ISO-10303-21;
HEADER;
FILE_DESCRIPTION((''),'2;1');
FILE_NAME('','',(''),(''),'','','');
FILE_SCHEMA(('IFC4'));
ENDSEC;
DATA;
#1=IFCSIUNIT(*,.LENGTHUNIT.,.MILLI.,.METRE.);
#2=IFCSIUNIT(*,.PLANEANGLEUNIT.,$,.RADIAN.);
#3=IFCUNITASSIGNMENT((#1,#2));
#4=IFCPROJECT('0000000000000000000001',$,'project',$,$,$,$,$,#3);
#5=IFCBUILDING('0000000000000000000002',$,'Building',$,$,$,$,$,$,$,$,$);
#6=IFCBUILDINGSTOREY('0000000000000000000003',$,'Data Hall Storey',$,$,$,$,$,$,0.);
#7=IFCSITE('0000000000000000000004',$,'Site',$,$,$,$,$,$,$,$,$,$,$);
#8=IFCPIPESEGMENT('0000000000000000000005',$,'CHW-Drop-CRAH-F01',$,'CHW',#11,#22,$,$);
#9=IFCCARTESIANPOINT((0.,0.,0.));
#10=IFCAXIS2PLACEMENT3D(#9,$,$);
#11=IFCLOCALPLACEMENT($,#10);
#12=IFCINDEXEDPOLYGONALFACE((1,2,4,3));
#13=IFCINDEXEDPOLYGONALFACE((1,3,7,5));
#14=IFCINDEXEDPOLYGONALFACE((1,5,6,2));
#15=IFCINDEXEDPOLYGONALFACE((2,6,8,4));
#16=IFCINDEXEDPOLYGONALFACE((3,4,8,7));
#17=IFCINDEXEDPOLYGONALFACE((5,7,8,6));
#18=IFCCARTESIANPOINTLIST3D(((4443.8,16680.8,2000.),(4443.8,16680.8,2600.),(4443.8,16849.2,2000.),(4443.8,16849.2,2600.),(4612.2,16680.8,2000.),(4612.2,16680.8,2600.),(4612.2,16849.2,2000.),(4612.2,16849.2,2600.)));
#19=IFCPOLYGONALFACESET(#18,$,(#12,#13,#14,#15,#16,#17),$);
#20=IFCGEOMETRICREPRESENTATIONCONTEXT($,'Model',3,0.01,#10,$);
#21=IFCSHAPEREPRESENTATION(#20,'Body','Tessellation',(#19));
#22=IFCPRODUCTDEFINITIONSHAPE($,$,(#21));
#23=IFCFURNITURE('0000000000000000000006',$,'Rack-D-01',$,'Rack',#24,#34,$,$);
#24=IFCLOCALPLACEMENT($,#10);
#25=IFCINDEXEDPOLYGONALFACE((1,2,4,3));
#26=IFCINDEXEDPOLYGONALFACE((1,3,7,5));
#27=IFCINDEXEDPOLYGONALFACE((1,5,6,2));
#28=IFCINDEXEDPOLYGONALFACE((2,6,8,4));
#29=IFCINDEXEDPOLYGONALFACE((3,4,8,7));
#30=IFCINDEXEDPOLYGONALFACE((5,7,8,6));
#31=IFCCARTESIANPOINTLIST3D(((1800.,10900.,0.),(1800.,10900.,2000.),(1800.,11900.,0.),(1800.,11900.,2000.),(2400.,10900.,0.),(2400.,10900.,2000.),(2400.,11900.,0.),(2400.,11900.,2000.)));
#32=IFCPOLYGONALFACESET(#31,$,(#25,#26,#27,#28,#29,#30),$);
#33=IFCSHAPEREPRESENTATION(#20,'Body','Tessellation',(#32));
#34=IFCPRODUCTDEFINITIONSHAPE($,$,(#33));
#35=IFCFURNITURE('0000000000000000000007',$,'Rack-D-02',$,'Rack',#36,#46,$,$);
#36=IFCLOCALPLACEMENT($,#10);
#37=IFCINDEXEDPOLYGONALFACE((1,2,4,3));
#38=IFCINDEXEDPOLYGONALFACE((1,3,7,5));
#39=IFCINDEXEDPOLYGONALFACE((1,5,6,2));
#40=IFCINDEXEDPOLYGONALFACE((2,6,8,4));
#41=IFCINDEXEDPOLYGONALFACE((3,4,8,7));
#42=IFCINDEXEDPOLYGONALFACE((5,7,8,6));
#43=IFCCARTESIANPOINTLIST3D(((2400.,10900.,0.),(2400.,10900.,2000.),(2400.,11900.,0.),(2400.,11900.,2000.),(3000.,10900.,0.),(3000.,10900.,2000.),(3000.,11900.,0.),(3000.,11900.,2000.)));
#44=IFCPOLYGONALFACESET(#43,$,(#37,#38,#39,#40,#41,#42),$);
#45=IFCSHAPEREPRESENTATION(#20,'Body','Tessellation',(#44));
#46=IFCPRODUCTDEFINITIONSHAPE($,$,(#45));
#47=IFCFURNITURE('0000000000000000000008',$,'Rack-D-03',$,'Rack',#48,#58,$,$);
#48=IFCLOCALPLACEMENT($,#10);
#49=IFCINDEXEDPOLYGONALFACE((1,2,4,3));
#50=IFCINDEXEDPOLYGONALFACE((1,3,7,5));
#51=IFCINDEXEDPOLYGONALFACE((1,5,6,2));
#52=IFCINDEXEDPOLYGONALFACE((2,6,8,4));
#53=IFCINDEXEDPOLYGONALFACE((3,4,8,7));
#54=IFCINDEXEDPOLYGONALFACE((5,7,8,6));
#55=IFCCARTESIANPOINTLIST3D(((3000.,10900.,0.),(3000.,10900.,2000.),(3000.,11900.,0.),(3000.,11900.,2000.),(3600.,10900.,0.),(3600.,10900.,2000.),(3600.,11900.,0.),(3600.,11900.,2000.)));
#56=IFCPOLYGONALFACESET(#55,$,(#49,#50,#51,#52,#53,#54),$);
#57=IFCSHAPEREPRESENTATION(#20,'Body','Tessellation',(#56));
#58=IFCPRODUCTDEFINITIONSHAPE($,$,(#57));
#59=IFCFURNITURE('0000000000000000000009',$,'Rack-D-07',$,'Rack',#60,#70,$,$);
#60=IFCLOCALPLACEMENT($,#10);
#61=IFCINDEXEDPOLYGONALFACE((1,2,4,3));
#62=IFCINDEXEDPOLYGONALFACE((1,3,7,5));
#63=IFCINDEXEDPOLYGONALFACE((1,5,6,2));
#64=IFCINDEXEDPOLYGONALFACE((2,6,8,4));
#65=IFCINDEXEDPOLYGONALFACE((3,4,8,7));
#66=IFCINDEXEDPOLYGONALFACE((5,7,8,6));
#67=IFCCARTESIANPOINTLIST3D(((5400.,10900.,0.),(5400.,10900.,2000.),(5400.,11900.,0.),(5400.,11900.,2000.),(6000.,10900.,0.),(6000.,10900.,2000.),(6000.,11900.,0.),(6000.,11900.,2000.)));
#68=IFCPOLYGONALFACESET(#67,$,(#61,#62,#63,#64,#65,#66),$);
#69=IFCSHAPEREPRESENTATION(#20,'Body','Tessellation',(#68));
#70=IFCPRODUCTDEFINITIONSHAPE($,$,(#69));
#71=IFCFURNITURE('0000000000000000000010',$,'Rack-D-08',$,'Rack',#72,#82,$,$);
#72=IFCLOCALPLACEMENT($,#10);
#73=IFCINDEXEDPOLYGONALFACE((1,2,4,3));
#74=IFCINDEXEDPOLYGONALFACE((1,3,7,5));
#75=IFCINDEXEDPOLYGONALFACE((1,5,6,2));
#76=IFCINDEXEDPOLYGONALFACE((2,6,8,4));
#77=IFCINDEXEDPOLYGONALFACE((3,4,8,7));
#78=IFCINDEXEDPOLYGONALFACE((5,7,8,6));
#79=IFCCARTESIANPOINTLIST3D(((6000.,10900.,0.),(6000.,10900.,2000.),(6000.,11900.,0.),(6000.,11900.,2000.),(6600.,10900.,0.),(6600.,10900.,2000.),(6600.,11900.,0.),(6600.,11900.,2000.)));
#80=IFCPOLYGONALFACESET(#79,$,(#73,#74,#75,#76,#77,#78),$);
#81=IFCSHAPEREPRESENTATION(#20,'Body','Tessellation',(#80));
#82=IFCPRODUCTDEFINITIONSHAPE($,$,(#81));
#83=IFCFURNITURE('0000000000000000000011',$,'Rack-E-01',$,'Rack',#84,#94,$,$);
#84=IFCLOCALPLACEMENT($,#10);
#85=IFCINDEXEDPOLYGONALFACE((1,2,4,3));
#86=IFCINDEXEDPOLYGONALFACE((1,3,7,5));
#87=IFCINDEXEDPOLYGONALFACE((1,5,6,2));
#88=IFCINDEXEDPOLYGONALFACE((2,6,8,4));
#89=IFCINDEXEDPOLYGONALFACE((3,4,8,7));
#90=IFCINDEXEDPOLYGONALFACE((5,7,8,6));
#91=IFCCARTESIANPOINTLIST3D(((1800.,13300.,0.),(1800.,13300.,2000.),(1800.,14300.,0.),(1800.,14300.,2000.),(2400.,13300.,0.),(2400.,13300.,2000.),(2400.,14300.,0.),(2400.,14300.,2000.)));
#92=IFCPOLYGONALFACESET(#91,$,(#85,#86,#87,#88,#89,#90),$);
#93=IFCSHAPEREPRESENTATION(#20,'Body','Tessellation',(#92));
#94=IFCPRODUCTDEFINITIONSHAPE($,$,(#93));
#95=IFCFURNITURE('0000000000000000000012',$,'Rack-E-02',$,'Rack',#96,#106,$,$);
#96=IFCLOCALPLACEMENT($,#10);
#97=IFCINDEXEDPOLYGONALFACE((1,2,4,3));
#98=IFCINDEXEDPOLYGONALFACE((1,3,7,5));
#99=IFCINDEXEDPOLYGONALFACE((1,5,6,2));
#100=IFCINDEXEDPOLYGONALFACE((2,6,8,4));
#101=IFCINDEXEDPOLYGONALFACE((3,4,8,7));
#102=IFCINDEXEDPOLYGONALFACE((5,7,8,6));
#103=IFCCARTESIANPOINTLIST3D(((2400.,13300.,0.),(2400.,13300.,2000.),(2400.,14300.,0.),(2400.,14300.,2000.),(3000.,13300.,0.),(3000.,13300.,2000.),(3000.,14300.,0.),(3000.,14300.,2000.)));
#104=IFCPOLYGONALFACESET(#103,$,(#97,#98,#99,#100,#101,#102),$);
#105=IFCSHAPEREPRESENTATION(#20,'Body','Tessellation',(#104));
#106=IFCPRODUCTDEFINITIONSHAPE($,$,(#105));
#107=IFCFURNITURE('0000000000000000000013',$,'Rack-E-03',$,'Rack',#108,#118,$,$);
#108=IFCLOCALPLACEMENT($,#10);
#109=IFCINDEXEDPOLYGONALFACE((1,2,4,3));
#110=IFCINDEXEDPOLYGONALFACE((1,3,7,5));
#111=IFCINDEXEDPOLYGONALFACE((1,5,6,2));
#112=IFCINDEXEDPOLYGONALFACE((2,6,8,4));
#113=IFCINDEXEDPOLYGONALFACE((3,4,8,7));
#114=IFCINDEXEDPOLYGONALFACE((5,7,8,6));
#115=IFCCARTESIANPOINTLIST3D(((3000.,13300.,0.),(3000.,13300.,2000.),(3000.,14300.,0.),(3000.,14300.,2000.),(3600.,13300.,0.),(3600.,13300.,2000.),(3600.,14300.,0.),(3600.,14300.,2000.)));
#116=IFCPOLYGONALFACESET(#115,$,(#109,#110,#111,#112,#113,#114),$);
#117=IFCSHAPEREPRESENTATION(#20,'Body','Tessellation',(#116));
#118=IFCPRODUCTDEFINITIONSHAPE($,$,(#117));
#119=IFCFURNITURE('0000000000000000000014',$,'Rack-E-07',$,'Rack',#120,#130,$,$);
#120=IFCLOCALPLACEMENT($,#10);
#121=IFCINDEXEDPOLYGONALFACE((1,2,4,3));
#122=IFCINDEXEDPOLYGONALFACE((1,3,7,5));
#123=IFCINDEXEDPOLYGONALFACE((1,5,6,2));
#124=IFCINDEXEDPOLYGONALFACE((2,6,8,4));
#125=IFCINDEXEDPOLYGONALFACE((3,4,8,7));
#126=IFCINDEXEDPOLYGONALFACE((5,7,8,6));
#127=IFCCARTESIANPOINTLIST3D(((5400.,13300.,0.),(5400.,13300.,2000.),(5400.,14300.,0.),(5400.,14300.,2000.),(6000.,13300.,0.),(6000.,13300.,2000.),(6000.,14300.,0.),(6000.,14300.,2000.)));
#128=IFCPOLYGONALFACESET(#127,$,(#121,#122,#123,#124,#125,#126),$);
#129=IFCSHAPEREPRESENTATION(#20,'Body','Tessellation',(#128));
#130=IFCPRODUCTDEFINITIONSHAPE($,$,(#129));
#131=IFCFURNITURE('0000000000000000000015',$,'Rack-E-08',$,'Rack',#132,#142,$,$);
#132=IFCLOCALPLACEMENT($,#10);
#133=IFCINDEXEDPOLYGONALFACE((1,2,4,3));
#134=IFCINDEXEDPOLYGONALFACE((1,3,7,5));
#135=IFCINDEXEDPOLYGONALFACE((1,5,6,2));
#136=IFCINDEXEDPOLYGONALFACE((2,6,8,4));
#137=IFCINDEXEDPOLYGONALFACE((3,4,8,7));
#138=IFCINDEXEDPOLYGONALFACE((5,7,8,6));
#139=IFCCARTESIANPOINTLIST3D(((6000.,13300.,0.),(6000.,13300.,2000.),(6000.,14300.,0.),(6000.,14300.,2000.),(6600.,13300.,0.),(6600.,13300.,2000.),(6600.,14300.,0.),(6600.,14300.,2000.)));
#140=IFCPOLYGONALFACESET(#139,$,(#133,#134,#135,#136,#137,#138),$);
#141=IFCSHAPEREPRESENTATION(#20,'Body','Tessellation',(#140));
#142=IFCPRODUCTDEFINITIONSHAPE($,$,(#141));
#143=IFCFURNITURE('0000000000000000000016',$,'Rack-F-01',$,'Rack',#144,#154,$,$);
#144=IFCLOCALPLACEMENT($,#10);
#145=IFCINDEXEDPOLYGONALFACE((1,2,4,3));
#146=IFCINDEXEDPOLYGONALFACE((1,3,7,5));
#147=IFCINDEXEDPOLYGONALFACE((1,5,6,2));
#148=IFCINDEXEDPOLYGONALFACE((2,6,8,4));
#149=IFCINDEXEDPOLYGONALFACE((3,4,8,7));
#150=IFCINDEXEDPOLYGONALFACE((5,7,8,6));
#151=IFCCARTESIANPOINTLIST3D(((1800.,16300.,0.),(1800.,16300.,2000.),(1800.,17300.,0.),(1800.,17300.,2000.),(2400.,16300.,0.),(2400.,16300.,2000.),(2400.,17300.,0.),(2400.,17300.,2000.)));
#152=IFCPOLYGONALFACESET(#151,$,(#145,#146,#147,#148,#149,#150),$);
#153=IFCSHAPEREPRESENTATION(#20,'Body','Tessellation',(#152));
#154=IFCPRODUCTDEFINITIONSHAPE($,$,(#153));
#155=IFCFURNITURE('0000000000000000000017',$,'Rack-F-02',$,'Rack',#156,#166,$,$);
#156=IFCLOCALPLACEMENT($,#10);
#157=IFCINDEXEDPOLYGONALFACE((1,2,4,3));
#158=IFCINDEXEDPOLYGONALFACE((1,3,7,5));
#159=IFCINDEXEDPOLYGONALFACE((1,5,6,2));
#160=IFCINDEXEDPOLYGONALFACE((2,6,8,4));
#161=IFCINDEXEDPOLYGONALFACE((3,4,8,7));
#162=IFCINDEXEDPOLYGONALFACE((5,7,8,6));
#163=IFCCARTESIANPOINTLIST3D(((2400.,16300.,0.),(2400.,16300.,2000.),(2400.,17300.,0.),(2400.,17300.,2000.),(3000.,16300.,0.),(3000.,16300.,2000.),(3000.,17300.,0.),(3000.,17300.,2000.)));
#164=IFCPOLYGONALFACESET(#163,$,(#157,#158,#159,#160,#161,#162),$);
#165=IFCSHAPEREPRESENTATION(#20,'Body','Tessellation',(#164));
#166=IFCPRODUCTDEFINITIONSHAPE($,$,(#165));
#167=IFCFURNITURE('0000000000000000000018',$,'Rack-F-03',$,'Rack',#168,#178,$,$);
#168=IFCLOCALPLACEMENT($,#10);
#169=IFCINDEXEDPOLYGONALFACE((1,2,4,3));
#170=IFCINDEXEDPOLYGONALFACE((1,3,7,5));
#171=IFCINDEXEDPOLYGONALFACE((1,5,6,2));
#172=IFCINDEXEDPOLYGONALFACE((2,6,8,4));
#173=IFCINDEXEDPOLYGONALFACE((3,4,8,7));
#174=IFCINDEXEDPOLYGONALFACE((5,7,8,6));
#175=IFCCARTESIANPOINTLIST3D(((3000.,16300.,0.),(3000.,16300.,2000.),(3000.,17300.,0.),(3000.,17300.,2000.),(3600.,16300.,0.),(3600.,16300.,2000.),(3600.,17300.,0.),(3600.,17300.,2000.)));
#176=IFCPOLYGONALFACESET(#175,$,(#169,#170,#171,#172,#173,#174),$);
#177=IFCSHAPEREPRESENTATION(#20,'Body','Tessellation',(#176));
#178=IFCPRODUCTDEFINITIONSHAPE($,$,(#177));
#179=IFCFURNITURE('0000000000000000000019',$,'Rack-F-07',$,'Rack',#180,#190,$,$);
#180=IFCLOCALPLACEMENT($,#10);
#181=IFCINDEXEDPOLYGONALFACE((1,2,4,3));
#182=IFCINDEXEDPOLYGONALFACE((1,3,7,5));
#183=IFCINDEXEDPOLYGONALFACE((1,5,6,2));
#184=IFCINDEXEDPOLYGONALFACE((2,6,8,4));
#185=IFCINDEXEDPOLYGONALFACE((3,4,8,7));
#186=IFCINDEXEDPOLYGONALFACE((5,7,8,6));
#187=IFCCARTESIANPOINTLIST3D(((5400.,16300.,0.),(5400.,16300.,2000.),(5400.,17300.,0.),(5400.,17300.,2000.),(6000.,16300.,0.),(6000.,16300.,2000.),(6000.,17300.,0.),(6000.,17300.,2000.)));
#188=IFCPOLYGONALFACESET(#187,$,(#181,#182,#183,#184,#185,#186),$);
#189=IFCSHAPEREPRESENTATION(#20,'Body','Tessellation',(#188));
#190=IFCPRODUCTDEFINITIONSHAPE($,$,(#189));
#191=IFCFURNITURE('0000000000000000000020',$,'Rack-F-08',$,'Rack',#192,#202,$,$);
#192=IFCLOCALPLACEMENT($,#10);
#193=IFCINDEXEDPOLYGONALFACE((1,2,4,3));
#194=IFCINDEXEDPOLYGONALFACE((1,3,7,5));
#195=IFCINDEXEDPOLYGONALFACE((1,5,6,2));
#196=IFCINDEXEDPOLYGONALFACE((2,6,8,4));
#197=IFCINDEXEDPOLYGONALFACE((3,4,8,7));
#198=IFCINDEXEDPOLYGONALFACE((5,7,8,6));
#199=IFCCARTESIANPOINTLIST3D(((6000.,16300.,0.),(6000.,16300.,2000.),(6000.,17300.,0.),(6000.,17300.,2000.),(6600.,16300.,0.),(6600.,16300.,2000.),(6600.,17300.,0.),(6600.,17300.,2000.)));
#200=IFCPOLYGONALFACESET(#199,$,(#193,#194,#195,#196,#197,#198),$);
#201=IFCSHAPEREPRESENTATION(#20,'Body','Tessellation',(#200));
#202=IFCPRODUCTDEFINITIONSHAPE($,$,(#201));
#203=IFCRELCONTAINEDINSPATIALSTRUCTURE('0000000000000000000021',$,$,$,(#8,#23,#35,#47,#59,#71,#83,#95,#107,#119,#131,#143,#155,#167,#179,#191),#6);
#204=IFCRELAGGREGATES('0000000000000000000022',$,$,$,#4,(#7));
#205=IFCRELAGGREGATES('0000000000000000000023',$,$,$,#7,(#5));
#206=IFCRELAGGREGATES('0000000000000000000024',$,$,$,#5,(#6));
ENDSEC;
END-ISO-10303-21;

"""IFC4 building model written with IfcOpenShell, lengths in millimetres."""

from ifc_helpers import new_model, si_unit, frame, origin, place, context, project, spatial, rectangle, extrude, element, save


model = new_model("IFC4")

# Units and contexts
model_context = context("Model", 3, precision=0.01, world=origin())
ifc_project = project(units=[si_unit("LENGTHUNIT", "METRE", prefix="MILLI"), si_unit("PLANEANGLEUNIT", "RADIAN")])

# Site, building, storey
site = spatial("IfcSite", under=ifc_project, Name="Site")
building = spatial("IfcBuilding", under=site, Name="Building")
storey = spatial("IfcBuildingStorey", under=building, Name="Data Hall Storey", Elevation=0.0)

# Pipe segment
pipe_segment_1_placement = place(None, frame((4528.0, 16765.0, 2000.0)))
element("IfcPipeSegment", 1, at=pipe_segment_1_placement, inside=storey, Name="CHW-Drop-CRAH-F01", ObjectType="CHW", context=model_context, shape_type="SweptSolid", body=[
    extrude(rectangle(XDim=168.3, YDim=168.3), origin(), (0.0, 0.0, 1.0), 600.0),
])

# Furniture
for number, where, name in (
    (2, (2100.0, 11400.0, 0.0), "Rack-D-01"),
    (3, (2700.0, 11400.0, 0.0), "Rack-D-02"),
    (4, (3300.0, 11400.0, 0.0), "Rack-D-03"),
    (5, (5700.0, 11400.0, 0.0), "Rack-D-07"),
    (6, (6300.0, 11400.0, 0.0), "Rack-D-08"),
    (7, (2100.0, 13800.0, 0.0), "Rack-E-01"),
    (8, (2700.0, 13800.0, 0.0), "Rack-E-02"),
    (9, (3300.0, 13800.0, 0.0), "Rack-E-03"),
    (10, (5700.0, 13800.0, 0.0), "Rack-E-07"),
    (11, (6300.0, 13800.0, 0.0), "Rack-E-08"),
    (12, (2100.0, 16800.0, 0.0), "Rack-F-01"),
    (13, (2700.0, 16800.0, 0.0), "Rack-F-02"),
    (14, (3300.0, 16800.0, 0.0), "Rack-F-03"),
    (15, (5700.0, 16800.0, 0.0), "Rack-F-07"),
    (16, (6300.0, 16800.0, 0.0), "Rack-F-08"),
):
    element("IfcFurniture", number, at=place(None, frame(where)), inside=storey, Name=name, ObjectType="Rack", context=model_context, shape_type="SweptSolid", body=[
        extrude(rectangle(XDim=600.0, YDim=1000.0), origin(), (0.0, 0.0, 1.0), 2000.0),
    ])

save(model, "model.ifc")
